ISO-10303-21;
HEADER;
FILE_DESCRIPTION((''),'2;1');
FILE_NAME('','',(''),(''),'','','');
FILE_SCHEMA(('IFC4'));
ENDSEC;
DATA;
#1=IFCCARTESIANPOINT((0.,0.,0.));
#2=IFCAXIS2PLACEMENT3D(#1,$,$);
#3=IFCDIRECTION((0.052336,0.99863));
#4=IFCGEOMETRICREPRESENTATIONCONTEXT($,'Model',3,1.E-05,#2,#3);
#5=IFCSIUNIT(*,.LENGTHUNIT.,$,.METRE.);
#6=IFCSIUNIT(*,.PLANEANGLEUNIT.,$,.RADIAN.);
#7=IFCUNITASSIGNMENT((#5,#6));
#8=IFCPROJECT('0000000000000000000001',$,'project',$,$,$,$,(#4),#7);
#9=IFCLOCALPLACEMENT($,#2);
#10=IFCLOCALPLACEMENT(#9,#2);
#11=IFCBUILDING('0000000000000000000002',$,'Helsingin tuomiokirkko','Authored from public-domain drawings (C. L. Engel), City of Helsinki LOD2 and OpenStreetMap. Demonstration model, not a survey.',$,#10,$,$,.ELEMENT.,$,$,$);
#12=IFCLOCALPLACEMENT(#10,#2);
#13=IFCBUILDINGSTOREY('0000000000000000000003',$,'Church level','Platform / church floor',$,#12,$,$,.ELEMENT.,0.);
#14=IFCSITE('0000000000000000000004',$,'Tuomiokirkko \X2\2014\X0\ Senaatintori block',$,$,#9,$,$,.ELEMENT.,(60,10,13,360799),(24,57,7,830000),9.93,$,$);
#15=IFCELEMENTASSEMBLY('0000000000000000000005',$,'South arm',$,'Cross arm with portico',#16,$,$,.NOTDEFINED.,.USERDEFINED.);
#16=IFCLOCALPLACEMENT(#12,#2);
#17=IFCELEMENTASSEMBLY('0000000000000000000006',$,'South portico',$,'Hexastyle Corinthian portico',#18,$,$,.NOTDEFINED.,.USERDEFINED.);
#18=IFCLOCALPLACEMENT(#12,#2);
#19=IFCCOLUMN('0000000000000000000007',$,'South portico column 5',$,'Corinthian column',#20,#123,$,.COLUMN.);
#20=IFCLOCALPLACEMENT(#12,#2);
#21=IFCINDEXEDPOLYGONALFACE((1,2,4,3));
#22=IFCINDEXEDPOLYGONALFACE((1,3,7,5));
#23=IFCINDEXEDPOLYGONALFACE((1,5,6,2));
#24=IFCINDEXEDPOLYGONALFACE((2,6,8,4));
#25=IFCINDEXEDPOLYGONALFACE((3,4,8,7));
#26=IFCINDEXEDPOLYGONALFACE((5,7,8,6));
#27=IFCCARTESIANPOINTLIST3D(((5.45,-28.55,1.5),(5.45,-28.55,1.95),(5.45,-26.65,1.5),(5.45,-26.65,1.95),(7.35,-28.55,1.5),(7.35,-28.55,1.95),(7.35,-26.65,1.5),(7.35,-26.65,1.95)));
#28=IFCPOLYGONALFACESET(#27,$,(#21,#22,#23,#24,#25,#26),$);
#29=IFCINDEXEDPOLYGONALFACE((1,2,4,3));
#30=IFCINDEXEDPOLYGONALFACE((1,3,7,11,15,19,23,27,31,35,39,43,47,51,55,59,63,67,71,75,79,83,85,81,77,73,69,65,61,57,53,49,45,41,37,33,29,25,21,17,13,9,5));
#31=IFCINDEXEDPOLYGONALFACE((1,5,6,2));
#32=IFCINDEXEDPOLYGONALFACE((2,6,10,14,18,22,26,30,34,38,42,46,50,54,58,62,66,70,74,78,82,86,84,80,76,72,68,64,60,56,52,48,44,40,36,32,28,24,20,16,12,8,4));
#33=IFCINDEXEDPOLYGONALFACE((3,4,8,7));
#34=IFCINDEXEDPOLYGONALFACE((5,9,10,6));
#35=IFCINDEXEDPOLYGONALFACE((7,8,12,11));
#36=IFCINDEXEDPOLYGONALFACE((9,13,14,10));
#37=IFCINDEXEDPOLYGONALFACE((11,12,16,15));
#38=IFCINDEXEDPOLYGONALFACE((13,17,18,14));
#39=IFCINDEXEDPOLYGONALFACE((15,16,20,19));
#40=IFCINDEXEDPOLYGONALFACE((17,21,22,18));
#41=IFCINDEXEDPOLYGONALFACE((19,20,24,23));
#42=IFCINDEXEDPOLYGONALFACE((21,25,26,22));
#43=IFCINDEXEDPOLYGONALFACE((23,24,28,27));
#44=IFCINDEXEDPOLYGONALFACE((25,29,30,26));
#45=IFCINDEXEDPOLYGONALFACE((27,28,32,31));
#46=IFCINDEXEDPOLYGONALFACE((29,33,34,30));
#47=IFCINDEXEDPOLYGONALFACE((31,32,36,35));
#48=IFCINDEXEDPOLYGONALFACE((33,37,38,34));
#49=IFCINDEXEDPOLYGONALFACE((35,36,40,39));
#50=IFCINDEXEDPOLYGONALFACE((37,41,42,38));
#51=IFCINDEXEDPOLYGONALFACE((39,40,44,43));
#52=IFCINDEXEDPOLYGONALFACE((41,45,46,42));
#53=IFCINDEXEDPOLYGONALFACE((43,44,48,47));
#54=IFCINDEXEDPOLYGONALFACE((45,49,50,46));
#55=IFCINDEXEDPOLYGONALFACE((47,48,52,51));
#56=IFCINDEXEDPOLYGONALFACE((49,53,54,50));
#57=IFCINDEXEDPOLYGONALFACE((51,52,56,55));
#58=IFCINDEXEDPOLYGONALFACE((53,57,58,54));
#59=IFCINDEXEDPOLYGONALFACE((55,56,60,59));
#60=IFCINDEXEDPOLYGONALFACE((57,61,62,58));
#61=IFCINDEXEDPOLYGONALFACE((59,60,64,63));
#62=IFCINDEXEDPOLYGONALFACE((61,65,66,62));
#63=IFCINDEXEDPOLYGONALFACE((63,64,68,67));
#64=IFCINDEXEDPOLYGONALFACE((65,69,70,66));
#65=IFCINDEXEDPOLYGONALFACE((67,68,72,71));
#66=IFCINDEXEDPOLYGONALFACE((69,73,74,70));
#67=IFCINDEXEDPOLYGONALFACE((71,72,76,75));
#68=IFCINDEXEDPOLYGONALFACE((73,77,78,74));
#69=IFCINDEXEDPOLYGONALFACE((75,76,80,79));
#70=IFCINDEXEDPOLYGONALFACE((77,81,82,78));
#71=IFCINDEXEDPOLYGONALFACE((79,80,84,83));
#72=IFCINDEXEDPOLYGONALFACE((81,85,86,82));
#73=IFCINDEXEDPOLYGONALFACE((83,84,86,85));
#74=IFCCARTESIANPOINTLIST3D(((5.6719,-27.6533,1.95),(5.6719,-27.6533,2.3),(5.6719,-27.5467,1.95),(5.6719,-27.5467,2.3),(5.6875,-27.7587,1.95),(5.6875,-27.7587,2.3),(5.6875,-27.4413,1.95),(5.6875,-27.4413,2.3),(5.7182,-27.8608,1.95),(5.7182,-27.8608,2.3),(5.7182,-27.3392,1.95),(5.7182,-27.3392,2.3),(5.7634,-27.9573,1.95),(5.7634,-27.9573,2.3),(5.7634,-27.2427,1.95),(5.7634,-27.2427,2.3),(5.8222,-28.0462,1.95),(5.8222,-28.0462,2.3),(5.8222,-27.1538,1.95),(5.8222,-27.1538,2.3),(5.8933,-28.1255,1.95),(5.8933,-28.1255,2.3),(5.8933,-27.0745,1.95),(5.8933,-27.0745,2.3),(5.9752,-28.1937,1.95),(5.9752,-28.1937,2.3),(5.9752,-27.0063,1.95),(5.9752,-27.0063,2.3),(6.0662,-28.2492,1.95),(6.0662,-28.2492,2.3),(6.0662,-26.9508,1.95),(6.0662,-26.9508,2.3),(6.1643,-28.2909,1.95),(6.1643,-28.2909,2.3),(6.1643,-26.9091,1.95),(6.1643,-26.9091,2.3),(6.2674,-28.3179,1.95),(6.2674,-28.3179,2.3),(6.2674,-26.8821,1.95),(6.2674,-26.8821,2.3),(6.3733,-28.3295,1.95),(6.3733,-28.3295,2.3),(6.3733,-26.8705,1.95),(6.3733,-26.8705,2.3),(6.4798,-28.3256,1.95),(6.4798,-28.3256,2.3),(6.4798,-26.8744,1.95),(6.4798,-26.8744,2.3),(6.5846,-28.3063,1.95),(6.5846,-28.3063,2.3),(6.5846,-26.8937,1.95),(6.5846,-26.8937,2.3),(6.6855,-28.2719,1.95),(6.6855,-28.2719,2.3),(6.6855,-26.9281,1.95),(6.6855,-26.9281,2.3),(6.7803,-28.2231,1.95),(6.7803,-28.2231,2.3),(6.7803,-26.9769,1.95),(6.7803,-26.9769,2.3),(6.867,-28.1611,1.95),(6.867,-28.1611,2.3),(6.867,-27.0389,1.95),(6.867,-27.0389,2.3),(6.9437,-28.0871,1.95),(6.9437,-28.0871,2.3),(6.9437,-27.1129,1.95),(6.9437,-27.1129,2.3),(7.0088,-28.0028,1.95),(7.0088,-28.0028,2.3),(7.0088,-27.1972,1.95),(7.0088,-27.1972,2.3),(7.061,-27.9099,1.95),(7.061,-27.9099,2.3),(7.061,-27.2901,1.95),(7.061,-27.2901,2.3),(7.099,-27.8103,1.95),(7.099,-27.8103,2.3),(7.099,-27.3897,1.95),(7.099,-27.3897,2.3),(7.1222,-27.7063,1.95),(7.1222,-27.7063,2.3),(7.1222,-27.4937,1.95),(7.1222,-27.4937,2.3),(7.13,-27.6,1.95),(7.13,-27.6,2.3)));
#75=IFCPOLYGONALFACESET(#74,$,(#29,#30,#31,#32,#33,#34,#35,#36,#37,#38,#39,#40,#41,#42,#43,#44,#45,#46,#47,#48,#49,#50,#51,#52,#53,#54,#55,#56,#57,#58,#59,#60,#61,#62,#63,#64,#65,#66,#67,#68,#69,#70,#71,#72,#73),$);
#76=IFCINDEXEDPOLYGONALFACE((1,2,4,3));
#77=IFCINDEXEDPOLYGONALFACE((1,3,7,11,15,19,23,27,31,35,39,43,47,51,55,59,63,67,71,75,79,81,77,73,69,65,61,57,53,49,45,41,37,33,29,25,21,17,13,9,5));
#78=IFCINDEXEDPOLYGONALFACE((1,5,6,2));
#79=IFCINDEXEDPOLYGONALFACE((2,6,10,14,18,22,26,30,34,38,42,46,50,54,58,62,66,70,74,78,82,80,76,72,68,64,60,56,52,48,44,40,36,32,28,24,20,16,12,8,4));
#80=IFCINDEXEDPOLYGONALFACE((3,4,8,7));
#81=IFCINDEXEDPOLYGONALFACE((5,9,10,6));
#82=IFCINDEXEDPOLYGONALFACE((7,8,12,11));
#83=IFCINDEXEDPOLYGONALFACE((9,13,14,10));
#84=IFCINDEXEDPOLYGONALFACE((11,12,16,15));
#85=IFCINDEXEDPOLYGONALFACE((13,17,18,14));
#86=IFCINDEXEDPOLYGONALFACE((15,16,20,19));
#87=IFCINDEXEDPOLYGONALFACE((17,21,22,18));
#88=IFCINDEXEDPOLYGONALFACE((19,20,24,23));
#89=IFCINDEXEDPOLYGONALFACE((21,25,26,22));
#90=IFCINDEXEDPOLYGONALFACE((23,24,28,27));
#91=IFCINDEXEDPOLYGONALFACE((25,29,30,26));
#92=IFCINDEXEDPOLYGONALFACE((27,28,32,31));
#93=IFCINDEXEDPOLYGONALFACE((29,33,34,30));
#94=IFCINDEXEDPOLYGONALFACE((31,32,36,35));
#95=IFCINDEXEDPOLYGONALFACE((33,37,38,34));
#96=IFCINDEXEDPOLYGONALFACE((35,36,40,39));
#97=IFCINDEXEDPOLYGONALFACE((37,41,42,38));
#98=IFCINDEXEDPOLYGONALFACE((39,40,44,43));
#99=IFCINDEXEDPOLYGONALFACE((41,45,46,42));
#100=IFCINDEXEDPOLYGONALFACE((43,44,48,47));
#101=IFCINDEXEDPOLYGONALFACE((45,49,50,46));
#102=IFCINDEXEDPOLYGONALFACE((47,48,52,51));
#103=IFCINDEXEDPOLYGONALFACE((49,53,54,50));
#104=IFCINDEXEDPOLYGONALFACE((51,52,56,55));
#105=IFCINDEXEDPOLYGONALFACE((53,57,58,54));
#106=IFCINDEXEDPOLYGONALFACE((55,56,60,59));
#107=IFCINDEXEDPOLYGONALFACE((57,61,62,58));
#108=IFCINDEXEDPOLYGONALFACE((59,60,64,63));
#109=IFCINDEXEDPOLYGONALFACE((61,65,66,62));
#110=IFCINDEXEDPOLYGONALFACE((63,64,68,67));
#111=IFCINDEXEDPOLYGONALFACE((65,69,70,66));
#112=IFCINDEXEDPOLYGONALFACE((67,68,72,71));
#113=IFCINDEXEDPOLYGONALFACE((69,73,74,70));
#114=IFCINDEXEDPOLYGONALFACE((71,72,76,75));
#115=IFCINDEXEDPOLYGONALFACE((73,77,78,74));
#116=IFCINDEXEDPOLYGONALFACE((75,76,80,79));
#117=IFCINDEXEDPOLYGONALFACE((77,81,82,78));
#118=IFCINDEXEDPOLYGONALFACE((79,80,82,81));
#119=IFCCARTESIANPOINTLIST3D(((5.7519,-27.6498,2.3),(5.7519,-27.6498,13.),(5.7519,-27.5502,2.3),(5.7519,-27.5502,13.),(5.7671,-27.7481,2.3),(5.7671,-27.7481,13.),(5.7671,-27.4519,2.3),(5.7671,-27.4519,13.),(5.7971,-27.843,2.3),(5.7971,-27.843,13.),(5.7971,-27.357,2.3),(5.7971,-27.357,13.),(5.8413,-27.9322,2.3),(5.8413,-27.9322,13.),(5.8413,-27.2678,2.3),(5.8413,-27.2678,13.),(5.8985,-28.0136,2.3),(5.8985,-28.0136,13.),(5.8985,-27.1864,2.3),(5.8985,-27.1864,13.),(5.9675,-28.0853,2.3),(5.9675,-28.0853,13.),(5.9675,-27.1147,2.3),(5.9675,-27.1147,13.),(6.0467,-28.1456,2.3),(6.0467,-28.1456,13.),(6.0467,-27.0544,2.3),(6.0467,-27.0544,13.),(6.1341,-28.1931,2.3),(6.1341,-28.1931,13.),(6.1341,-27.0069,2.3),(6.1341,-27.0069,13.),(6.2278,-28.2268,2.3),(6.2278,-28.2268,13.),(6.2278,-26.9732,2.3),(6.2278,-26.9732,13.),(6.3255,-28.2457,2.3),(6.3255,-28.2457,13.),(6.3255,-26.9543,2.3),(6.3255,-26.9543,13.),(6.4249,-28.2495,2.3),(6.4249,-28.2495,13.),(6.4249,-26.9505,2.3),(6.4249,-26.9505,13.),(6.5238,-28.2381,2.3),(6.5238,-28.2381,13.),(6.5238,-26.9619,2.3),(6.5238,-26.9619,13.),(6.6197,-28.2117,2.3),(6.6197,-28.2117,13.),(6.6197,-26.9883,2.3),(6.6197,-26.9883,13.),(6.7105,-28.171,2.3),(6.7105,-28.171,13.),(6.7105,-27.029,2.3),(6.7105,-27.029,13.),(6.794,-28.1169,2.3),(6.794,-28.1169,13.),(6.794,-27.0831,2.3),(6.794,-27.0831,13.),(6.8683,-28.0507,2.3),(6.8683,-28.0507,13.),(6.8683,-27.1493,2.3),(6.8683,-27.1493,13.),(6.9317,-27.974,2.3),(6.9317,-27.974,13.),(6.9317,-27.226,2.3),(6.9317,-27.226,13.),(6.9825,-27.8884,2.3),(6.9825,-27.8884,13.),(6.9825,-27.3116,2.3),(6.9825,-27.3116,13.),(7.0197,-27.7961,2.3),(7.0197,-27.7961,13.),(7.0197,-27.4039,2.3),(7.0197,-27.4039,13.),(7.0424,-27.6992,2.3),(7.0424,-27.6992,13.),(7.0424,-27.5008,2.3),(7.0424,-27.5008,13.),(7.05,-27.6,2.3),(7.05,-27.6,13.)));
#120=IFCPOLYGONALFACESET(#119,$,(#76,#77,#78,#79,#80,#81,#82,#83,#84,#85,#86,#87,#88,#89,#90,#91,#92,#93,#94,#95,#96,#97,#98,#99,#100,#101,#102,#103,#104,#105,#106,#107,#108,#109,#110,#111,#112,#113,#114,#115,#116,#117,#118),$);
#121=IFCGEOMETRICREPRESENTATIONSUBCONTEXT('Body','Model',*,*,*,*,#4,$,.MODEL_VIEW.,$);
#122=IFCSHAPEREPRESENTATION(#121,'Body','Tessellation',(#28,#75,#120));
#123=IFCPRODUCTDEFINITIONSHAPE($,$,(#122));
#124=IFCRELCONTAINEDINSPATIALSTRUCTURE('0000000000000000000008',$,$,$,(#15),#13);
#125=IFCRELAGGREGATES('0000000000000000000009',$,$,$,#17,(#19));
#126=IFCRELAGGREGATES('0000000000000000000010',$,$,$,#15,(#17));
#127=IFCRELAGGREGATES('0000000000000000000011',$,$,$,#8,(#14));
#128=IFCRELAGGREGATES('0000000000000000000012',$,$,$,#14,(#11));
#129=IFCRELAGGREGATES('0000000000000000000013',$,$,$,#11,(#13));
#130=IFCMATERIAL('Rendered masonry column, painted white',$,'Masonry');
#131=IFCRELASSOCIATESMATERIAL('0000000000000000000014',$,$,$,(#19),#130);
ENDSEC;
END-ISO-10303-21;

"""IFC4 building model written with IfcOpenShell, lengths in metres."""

from ifc_helpers import new_model, si_unit, direction, frame, origin, origin_2d_with_axis, place, context, subcontext, project, spatial, rectangle, circle, extrude, material, element, aggregate, save


model = new_model("IFC4")

# Units and contexts
model_context = context("Model", 3, precision=1e-05, world=origin(), true_north=direction((0.052336, 0.99863)))
body_context = subcontext(model_context, "Body", "Model", "MODEL_VIEW")
ifc_project = project(units=[si_unit("LENGTHUNIT", "METRE"), si_unit("PLANEANGLEUNIT", "RADIAN")], contexts=[model_context])

# Site, building, storey
site_placement = place(None, origin())
site = spatial("IfcSite", under=ifc_project, at=site_placement, Name="Tuomiokirkko — Senaatintori block", CompositionType="ELEMENT", RefLatitude=(60, 10, 13, 360799), RefLongitude=(24, 57, 7, 830000), RefElevation=9.93)
building_placement = place(site_placement, origin())
building = spatial("IfcBuilding", under=site, at=building_placement, Name="Helsingin tuomiokirkko", Description="Authored from public-domain drawings (C. L. Engel), City of Helsinki LOD2 and OpenStreetMap. Demonstration model, not a survey.", CompositionType="ELEMENT")
storey_placement = place(building_placement, origin())
storey = spatial("IfcBuildingStorey", under=building, at=storey_placement, Name="Church level", Description="Platform / church floor", CompositionType="ELEMENT", Elevation=0.0)

# Element assemblies, column
assembly_1_placement = place(building_placement, origin())
assembly_1 = element("IfcElementAssembly", 1, at=assembly_1_placement, inside=storey, Name="South arm", ObjectType="Cross arm with portico", AssemblyPlace="NOTDEFINED", PredefinedType="USERDEFINED")
assembly_2_placement = place(building_placement, origin())
assembly_2 = element("IfcElementAssembly", 2, at=assembly_2_placement, Name="South portico", ObjectType="Hexastyle Corinthian portico", AssemblyPlace="NOTDEFINED", PredefinedType="USERDEFINED")
ifc_material_1 = material(Name="Rendered masonry column, painted white", Category="Masonry")
column_1_placement = place(building_placement, origin())
column_1 = element("IfcColumn", 3, at=column_1_placement, material=ifc_material_1, Name="South portico column 5", ObjectType="Corinthian column", PredefinedType="COLUMN", context=body_context, shape_type="SweptSolid", body=[
    extrude(rectangle(XDim=1.9, YDim=1.9, at=origin_2d_with_axis()), frame((6.4, -27.6, 1.5)), (0.0, 0.0, 1.0), 0.45),
    extrude(circle(Radius=0.73, at=origin_2d_with_axis()), frame((6.4, -27.6, 1.95)), (0.0, 0.0, 1.0), 0.35),
    extrude(circle(Radius=0.65, at=origin_2d_with_axis()), frame((6.4, -27.6, 2.3)), (0.0, 0.0, 1.0), 10.7),
])

aggregate(assembly_2, [column_1])

aggregate(assembly_1, [assembly_2])

save(model, "model.ifc")
